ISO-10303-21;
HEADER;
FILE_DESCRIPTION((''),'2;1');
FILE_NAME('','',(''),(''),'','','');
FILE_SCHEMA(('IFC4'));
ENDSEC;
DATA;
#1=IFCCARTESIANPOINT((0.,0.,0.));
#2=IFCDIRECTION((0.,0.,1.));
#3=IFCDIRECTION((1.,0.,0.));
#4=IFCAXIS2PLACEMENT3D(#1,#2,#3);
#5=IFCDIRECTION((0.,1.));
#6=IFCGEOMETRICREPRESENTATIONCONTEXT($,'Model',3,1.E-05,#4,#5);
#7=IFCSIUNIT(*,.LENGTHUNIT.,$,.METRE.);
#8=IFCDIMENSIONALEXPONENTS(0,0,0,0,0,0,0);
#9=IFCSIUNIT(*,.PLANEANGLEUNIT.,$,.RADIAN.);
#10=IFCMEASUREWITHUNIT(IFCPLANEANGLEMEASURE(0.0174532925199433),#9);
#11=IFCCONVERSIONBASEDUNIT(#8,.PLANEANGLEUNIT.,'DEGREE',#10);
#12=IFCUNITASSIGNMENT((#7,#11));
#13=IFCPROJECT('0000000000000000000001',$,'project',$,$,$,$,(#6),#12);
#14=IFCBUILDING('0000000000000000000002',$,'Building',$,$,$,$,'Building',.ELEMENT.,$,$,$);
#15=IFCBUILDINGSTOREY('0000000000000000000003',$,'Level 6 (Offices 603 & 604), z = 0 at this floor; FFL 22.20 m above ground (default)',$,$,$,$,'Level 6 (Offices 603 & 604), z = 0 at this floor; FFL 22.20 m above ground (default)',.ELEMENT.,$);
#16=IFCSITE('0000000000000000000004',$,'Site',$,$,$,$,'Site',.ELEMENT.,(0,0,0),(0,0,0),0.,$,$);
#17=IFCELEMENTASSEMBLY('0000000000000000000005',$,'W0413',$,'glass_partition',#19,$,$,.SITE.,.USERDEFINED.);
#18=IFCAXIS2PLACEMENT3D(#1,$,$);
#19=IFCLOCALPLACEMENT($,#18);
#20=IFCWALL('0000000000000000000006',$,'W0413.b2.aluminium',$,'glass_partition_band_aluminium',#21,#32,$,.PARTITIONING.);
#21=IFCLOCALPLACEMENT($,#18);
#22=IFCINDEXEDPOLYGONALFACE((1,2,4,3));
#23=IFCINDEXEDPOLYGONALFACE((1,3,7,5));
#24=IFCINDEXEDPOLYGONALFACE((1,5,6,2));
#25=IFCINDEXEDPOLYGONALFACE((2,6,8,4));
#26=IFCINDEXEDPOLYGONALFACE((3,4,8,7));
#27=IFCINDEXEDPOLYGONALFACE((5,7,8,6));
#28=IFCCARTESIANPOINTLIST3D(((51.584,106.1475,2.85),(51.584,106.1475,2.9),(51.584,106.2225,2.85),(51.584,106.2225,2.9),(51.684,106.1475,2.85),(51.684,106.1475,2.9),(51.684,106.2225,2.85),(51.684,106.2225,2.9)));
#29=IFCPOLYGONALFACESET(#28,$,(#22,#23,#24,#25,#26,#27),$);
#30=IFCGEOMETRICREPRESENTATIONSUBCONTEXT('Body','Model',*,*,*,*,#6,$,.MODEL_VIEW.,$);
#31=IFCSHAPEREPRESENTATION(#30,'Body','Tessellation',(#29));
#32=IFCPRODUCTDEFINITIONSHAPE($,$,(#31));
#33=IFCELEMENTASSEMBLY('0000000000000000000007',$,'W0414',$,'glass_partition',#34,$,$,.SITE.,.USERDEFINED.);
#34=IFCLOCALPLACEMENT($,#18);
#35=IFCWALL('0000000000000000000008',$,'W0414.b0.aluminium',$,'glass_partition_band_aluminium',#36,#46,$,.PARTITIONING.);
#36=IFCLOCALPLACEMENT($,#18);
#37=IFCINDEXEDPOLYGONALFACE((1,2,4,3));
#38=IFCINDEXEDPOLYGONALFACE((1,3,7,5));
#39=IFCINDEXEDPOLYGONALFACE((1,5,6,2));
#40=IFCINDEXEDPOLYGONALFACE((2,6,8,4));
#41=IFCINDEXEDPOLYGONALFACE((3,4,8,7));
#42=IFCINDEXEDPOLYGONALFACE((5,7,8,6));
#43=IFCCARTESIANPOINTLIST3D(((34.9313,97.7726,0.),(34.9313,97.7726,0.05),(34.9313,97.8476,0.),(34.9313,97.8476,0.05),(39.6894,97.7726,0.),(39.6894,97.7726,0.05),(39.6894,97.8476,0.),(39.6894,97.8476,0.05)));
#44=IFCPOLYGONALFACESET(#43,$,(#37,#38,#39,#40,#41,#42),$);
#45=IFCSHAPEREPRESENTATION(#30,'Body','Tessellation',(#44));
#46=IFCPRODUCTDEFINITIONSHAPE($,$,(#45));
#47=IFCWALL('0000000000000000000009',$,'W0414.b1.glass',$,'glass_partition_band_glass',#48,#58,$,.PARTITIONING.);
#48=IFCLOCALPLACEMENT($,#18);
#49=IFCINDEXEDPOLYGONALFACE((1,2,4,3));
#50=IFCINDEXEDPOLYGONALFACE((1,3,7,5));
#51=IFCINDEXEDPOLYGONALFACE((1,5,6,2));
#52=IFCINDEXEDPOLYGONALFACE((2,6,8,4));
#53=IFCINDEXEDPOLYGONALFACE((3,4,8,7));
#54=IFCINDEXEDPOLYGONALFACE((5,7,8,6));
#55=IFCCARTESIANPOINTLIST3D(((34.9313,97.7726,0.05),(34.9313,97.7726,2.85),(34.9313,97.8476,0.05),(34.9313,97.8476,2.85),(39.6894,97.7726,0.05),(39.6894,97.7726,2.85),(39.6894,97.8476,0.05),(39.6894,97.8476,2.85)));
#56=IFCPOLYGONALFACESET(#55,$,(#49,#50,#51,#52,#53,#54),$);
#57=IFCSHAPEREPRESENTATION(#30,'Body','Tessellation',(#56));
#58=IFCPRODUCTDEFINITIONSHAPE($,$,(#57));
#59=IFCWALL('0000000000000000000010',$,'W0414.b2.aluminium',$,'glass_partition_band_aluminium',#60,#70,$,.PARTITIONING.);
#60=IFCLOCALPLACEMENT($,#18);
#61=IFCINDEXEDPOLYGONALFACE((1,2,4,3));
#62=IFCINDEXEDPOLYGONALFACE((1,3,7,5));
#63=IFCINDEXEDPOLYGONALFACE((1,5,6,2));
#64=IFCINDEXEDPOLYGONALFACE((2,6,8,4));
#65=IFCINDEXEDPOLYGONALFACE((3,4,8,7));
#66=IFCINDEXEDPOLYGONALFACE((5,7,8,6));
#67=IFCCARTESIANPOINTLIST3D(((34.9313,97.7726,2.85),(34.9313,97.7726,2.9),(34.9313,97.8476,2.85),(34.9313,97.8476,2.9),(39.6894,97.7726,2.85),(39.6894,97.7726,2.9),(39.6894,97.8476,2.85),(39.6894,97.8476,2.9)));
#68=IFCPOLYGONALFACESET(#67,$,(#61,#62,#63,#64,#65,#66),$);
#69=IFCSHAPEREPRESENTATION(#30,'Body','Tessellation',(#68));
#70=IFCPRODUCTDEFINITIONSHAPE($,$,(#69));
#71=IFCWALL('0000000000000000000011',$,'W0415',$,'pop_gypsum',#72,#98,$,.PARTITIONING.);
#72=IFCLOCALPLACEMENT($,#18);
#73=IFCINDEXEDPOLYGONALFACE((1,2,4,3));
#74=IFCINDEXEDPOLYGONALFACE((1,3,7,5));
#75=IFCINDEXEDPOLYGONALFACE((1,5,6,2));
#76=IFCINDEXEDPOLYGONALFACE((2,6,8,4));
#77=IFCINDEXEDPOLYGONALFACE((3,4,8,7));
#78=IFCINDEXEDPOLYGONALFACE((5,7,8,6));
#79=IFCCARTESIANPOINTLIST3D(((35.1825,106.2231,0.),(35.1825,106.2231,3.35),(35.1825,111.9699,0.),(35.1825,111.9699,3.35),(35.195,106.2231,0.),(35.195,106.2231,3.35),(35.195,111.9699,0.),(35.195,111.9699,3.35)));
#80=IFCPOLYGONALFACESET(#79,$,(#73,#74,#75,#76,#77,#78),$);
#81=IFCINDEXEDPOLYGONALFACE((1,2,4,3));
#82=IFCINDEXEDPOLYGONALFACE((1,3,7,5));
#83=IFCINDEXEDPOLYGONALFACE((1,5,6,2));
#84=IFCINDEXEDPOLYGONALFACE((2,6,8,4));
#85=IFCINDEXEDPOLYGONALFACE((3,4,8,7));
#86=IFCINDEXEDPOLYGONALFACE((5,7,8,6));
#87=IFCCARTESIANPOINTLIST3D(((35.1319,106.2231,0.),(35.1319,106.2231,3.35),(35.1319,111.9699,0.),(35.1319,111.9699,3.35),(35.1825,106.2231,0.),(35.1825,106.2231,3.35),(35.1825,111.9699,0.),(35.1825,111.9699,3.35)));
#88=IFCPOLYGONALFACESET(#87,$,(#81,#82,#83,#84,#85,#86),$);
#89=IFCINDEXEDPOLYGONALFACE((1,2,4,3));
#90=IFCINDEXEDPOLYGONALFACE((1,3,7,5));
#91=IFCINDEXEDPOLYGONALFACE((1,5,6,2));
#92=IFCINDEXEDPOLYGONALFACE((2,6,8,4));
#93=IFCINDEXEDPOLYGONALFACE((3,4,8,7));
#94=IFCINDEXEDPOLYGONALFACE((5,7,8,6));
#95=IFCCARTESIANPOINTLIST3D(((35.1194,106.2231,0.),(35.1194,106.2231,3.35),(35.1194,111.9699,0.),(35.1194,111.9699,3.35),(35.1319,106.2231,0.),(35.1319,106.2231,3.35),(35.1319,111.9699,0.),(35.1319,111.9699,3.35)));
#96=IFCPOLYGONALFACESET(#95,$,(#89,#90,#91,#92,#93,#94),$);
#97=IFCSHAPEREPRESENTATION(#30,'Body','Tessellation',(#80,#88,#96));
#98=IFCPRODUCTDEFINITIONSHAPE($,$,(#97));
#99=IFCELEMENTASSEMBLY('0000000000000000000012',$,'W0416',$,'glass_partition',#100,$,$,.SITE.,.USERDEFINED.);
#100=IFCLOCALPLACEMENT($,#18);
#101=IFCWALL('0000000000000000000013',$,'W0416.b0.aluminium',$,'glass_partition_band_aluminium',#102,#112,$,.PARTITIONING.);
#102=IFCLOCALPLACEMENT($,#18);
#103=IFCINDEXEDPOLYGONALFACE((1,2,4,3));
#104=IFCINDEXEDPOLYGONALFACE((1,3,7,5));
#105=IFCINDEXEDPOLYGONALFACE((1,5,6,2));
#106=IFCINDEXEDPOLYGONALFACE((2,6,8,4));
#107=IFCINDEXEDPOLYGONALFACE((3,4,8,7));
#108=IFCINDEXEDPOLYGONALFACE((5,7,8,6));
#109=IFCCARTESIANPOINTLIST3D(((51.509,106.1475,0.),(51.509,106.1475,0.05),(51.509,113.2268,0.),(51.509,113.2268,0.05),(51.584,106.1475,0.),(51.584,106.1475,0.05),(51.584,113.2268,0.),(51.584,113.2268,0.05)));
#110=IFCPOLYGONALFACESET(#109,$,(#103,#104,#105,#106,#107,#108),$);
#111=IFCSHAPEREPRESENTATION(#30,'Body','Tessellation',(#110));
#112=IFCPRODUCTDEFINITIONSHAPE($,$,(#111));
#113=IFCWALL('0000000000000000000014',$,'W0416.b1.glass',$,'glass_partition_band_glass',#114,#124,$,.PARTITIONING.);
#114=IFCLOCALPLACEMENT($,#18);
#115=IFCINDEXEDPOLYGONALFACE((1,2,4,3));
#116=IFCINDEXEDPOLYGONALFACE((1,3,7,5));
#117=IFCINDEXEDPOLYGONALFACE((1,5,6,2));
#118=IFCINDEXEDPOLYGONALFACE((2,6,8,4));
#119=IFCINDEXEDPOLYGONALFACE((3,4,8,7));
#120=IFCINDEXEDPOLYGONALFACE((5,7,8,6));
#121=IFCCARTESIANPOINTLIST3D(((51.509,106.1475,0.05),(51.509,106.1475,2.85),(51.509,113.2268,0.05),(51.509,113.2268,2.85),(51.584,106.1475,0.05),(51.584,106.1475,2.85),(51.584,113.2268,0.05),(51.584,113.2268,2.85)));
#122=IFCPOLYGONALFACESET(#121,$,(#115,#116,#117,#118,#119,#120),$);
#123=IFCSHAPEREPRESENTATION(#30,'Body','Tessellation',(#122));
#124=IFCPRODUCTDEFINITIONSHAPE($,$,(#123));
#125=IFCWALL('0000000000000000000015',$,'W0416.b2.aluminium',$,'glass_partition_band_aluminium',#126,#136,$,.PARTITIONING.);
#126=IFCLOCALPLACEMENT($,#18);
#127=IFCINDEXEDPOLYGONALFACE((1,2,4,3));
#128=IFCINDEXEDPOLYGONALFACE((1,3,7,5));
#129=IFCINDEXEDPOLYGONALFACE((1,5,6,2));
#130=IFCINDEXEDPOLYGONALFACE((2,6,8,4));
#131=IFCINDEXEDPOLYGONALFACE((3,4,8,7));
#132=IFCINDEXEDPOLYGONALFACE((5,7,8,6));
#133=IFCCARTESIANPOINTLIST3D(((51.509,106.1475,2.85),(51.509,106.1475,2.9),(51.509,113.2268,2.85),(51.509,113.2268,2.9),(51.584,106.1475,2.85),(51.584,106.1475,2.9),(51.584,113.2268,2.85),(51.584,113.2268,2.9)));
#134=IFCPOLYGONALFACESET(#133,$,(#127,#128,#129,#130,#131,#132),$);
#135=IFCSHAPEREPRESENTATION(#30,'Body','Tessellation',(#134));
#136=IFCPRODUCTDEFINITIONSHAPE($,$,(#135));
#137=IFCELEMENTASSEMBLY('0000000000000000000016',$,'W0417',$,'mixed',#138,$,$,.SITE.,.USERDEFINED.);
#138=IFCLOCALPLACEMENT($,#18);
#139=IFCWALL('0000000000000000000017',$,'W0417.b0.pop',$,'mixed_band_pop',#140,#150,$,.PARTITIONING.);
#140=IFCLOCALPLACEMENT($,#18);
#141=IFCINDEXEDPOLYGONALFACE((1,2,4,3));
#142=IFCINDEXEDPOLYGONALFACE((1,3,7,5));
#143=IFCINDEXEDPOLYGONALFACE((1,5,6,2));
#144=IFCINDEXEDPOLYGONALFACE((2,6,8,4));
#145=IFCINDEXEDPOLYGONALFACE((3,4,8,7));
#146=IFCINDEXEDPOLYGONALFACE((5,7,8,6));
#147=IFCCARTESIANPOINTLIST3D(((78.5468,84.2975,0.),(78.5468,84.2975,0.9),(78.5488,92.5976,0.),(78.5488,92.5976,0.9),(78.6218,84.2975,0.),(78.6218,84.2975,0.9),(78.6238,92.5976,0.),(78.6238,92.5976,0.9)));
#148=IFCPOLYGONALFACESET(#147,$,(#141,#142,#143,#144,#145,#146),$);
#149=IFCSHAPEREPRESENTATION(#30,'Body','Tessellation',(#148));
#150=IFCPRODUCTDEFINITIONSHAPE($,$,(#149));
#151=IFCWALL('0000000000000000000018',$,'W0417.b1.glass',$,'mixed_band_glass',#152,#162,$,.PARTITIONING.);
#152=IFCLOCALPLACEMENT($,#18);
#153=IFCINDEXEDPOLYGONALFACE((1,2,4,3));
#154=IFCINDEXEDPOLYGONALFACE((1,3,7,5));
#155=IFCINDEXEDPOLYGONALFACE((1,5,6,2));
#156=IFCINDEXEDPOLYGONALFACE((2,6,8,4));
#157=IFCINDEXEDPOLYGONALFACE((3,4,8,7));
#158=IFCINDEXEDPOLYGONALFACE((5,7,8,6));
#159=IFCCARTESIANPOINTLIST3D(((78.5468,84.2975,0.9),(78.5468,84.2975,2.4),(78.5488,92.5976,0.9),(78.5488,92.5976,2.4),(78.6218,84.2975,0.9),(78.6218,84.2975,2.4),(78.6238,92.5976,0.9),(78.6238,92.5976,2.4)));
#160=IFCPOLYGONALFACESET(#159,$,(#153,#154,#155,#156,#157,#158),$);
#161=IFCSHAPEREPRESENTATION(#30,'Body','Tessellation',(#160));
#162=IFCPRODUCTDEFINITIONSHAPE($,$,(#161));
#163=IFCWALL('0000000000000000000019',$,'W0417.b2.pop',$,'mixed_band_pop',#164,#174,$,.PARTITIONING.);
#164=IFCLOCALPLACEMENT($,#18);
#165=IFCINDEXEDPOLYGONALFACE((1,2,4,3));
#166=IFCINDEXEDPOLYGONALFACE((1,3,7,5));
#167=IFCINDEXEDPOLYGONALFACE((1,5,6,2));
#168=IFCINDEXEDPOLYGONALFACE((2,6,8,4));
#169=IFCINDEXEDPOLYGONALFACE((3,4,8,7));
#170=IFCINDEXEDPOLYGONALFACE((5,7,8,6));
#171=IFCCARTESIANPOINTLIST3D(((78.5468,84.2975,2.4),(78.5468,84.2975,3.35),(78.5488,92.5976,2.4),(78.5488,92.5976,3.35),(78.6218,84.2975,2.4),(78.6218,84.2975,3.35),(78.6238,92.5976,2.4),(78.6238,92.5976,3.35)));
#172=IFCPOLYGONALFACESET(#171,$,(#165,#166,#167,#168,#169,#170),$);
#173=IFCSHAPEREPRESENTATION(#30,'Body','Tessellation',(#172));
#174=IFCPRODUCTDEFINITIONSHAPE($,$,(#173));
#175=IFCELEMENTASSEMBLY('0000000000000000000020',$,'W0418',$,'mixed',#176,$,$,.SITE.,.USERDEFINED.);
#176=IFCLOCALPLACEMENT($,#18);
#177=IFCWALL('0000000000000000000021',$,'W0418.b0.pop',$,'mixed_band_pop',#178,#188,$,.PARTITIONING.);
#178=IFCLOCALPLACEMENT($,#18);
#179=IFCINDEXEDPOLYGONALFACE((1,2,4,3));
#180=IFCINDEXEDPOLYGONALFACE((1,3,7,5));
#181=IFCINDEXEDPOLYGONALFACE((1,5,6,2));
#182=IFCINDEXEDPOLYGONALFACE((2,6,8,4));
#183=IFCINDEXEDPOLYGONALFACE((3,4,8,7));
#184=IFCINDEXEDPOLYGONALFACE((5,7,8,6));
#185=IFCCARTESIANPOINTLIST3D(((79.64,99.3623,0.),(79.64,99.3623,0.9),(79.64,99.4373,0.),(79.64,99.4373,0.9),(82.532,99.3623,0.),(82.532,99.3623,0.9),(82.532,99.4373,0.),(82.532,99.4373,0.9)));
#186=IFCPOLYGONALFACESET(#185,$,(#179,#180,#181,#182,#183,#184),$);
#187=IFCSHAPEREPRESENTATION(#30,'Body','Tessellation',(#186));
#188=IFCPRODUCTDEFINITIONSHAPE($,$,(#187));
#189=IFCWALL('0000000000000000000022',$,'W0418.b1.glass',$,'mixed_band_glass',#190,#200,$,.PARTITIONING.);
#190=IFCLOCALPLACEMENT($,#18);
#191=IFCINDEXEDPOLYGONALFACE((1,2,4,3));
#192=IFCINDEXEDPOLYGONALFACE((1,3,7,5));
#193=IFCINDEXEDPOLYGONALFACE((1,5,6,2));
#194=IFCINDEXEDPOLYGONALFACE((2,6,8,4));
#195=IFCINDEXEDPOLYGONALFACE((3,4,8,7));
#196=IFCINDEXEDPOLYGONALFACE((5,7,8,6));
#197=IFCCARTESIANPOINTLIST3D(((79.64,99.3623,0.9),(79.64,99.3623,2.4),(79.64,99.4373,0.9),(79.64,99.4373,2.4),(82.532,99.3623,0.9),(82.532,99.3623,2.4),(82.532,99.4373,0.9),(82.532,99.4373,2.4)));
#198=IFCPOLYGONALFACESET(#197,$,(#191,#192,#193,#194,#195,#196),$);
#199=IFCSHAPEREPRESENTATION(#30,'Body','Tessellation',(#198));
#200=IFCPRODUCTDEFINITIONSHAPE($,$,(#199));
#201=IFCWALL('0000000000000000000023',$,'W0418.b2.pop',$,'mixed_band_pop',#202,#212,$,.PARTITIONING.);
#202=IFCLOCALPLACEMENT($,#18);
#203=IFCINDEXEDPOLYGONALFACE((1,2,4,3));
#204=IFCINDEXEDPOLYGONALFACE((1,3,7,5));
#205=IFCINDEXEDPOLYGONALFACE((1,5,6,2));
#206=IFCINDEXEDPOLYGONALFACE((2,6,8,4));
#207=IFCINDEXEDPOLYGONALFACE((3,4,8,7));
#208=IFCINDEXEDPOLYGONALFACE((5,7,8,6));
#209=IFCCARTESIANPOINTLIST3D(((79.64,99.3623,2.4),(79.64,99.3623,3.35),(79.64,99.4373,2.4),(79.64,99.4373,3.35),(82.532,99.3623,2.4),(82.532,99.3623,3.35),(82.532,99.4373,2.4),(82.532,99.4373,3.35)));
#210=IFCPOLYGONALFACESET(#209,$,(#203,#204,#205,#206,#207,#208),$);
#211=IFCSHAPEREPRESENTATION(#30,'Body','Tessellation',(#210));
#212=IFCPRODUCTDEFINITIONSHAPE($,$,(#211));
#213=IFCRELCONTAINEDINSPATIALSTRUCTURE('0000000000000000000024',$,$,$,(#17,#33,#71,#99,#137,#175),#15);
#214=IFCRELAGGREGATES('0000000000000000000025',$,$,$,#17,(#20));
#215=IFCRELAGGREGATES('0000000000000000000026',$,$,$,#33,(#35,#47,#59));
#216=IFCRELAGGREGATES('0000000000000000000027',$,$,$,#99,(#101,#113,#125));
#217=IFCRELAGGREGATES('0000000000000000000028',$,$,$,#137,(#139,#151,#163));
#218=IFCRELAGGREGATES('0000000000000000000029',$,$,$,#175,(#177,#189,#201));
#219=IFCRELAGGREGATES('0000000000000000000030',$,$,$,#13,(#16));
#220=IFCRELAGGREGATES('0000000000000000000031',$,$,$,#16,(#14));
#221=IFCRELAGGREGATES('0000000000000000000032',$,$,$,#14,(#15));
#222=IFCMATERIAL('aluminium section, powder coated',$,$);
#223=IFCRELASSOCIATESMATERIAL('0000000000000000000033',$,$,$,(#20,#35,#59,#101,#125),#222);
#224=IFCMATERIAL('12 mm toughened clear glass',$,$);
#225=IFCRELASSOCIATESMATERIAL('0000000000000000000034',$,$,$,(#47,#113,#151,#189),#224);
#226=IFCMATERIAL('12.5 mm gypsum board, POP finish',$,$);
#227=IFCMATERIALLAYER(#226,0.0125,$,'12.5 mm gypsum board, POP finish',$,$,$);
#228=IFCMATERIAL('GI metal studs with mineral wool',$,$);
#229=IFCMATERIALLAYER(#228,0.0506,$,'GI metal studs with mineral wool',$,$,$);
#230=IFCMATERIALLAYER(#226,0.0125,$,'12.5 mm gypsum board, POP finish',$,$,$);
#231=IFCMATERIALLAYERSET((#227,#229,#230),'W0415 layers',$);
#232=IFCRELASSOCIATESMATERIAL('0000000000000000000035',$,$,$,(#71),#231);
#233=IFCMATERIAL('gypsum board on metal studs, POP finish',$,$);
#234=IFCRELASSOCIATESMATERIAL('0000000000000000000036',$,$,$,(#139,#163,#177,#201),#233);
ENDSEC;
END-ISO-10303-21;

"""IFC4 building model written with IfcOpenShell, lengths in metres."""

from ifc_helpers import new_model, entity, si_unit, converted_unit, direction, frame, frame_2d, origin_with_axes, place, context, subcontext, project, spatial, rectangle, extrude, material, layer, layer_set, layer_usage, element, aggregate, save


model = new_model("IFC4")

# Units and contexts
model_context = context("Model", 3, precision=1e-05, world=origin_with_axes(), true_north=direction((0.0, 1.0)))
body_context = subcontext(model_context, "Body", "Model", "MODEL_VIEW")
ifc_project = project(units=[si_unit("LENGTHUNIT", "METRE"), converted_unit("PLANEANGLEUNIT", "DEGREE", entity("IfcPlaneAngleMeasure", 0.0174532925199433), si_unit("PLANEANGLEUNIT", "RADIAN"), dimensions=[0, 0, 0, 0, 0, 0, 0])], contexts=[model_context])

# Site, building, storey
site = spatial("IfcSite", under=ifc_project, Name="Site", LongName="Site", CompositionType="ELEMENT", RefLatitude=(0, 0, 0), RefLongitude=(0, 0, 0), RefElevation=0.0)
building = spatial("IfcBuilding", under=site, Name="Building", LongName="Building", CompositionType="ELEMENT")
storey = spatial("IfcBuildingStorey", under=building, Name="Level 6 (Offices 603 & 604), z = 0 at this floor; FFL 22.20 m above ground (default)", LongName="Level 6 (Offices 603 & 604), z = 0 at this floor; FFL 22.20 m above ground (default)", CompositionType="ELEMENT")

# Element assembly, wall
assembly_1 = element("IfcElementAssembly", 1, inside=storey, Name="W0413", ObjectType="glass_partition", AssemblyPlace="SITE", PredefinedType="USERDEFINED")
ifc_material_1 = material(Name="aluminium section, powder coated")
placement = place(None, origin_with_axes())
wall_1 = element("IfcWall", 2, at=placement, material=ifc_material_1, Name="W0413.b2.aluminium", ObjectType="glass_partition_band_aluminium", PredefinedType="PARTITIONING", context=body_context, shape_type="SweptSolid", body=[
    extrude(rectangle(XDim=0.1, YDim=0.075, at=frame_2d((0.0, 0.0), x_axis=(1.0, 0.0))), frame((51.634, 106.185, 2.85), z_axis=(0.0, 0.0, 1.0), x_axis=(1.0, 0.0, 0.0)), (0.0, 0.0, 1.0), 0.05),
])
aggregate(assembly_1, [wall_1])

# Element assembly, walls
assembly_2 = element("IfcElementAssembly", 3, inside=storey, Name="W0414", ObjectType="glass_partition", AssemblyPlace="SITE", PredefinedType="USERDEFINED")
wall_2 = element("IfcWall", 4, at=placement, material=ifc_material_1, Name="W0414.b0.aluminium", ObjectType="glass_partition_band_aluminium", PredefinedType="PARTITIONING", context=body_context, shape_type="SweptSolid", body=[
    extrude(rectangle(XDim=4.7581, YDim=0.075, at=frame_2d((0.0, 0.0), x_axis=(1.0, 0.0))), frame((37.3103, 97.8101, 0.0), z_axis=(0.0, 0.0, 1.0), x_axis=(1.0, 0.0, 0.0)), (0.0, 0.0, 1.0), 0.05),
])
ifc_material_2 = material(Name="12 mm toughened clear glass")
wall_3 = element("IfcWall", 5, at=placement, material=ifc_material_2, Name="W0414.b1.glass", ObjectType="glass_partition_band_glass", PredefinedType="PARTITIONING", context=body_context, shape_type="SweptSolid", body=[
    extrude(rectangle(XDim=4.7581, YDim=0.075, at=frame_2d((0.0, 0.0), x_axis=(1.0, 0.0))), frame((37.3103, 97.8101, 0.05), z_axis=(0.0, 0.0, 1.0), x_axis=(1.0, 0.0, 0.0)), (0.0, 0.0, 1.0), 2.8),
])
wall_4 = element("IfcWall", 6, at=placement, material=ifc_material_1, Name="W0414.b2.aluminium", ObjectType="glass_partition_band_aluminium", PredefinedType="PARTITIONING", context=body_context, shape_type="SweptSolid", body=[
    extrude(rectangle(XDim=4.7581, YDim=0.075, at=frame_2d((0.0, 0.0), x_axis=(1.0, 0.0))), frame((37.3103, 97.8101, 2.85), z_axis=(0.0, 0.0, 1.0), x_axis=(1.0, 0.0, 0.0)), (0.0, 0.0, 1.0), 0.05),
])
aggregate(assembly_2, [wall_2, wall_3, wall_4])

# Wall
ifc_material_3 = material(Name="12.5 mm gypsum board, POP finish")
ifc_layer_1 = layer(ifc_material_3, 0.0125, Name="12.5 mm gypsum board, POP finish")
ifc_material_4 = material(Name="GI metal studs with mineral wool")
ifc_layer_2 = layer(ifc_material_4, 0.0506, Name="GI metal studs with mineral wool")
ifc_layer_3 = layer(ifc_material_3, 0.0125, Name="12.5 mm gypsum board, POP finish")
ifc_layer_set = layer_set([ifc_layer_1, ifc_layer_2, ifc_layer_3], Name="W0415 layers")
ifc_layer_usage = layer_usage(ifc_layer_set, "AXIS2", "POSITIVE", -0.0378)
element("IfcWall", 7, at=placement, inside=storey, material=ifc_layer_usage, Name="W0415", ObjectType="pop_gypsum", PredefinedType="PARTITIONING", context=body_context, shape_type="SweptSolid", body=[
    extrude(rectangle(XDim=5.7468, YDim=0.0125, at=frame_2d((0.0, 0.0), x_axis=(0.0, 1.0))), frame((35.1887, 109.0965, 0.0), z_axis=(0.0, 0.0, 1.0), x_axis=(1.0, 0.0, 0.0)), (0.0, 0.0, 1.0), 3.35),
    extrude(rectangle(XDim=5.7468, YDim=0.0506, at=frame_2d((-0.0315, 0.0), x_axis=(0.0, 1.0))), frame((35.1887, 109.0965, 0.0), z_axis=(0.0, 0.0, 1.0), x_axis=(1.0, 0.0, 0.0)), (0.0, 0.0, 1.0), 3.35),
    extrude(rectangle(XDim=5.7468, YDim=0.0125, at=frame_2d((-0.0631, 0.0), x_axis=(0.0, 1.0))), frame((35.1887, 109.0965, 0.0), z_axis=(0.0, 0.0, 1.0), x_axis=(1.0, 0.0, 0.0)), (0.0, 0.0, 1.0), 3.35),
])

# Element assemblies, walls
assembly_3 = element("IfcElementAssembly", 8, inside=storey, Name="W0416", ObjectType="glass_partition", AssemblyPlace="SITE", PredefinedType="USERDEFINED")
wall_5 = element("IfcWall", 9, at=placement, material=ifc_material_1, Name="W0416.b0.aluminium", ObjectType="glass_partition_band_aluminium", PredefinedType="PARTITIONING", context=body_context, shape_type="SweptSolid", body=[
    extrude(rectangle(XDim=7.0793, YDim=0.075, at=frame_2d((0.0, 0.0), x_axis=(0.0, 1.0))), frame((51.5465, 109.6872, 0.0), z_axis=(0.0, 0.0, 1.0), x_axis=(1.0, 0.0, 0.0)), (0.0, 0.0, 1.0), 0.05),
])
wall_6 = element("IfcWall", 10, at=placement, material=ifc_material_2, Name="W0416.b1.glass", ObjectType="glass_partition_band_glass", PredefinedType="PARTITIONING", context=body_context, shape_type="SweptSolid", body=[
    extrude(rectangle(XDim=7.0793, YDim=0.075, at=frame_2d((0.0, 0.0), x_axis=(0.0, 1.0))), frame((51.5465, 109.6872, 0.05), z_axis=(0.0, 0.0, 1.0), x_axis=(1.0, 0.0, 0.0)), (0.0, 0.0, 1.0), 2.8),
])
wall_7 = element("IfcWall", 11, at=placement, material=ifc_material_1, Name="W0416.b2.aluminium", ObjectType="glass_partition_band_aluminium", PredefinedType="PARTITIONING", context=body_context, shape_type="SweptSolid", body=[
    extrude(rectangle(XDim=7.0793, YDim=0.075, at=frame_2d((0.0, 0.0), x_axis=(0.0, 1.0))), frame((51.5465, 109.6872, 2.85), z_axis=(0.0, 0.0, 1.0), x_axis=(1.0, 0.0, 0.0)), (0.0, 0.0, 1.0), 0.05),
])
aggregate(assembly_3, [wall_5, wall_6, wall_7])
assembly_4 = element("IfcElementAssembly", 12, inside=storey, Name="W0417", ObjectType="mixed", AssemblyPlace="SITE", PredefinedType="USERDEFINED")
ifc_material_5 = material(Name="gypsum board on metal studs, POP finish")
wall_8 = element("IfcWall", 13, at=placement, material=ifc_material_5, Name="W0417.b0.pop", ObjectType="mixed_band_pop", PredefinedType="PARTITIONING", context=body_context, shape_type="SweptSolid", body=[
    extrude(rectangle(XDim=8.3001, YDim=0.075, at=frame_2d((0.0, 0.0), x_axis=(0.000241, 1.0))), frame((78.5853, 88.4476, 0.0), z_axis=(0.0, 0.0, 1.0), x_axis=(1.0, 0.0, 0.0)), (0.0, 0.0, 1.0), 0.9),
])
wall_9 = element("IfcWall", 14, at=placement, material=ifc_material_2, Name="W0417.b1.glass", ObjectType="mixed_band_glass", PredefinedType="PARTITIONING", context=body_context, shape_type="SweptSolid", body=[
    extrude(rectangle(XDim=8.3001, YDim=0.075, at=frame_2d((0.0, 0.0), x_axis=(0.000241, 1.0))), frame((78.5853, 88.4476, 0.9), z_axis=(0.0, 0.0, 1.0), x_axis=(1.0, 0.0, 0.0)), (0.0, 0.0, 1.0), 1.5),
])
wall_10 = element("IfcWall", 15, at=placement, material=ifc_material_5, Name="W0417.b2.pop", ObjectType="mixed_band_pop", PredefinedType="PARTITIONING", context=body_context, shape_type="SweptSolid", body=[
    extrude(rectangle(XDim=8.3001, YDim=0.075, at=frame_2d((0.0, 0.0), x_axis=(0.000241, 1.0))), frame((78.5853, 88.4476, 2.4), z_axis=(0.0, 0.0, 1.0), x_axis=(1.0, 0.0, 0.0)), (0.0, 0.0, 1.0), 0.95),
])
aggregate(assembly_4, [wall_8, wall_9, wall_10])
assembly_5 = element("IfcElementAssembly", 16, inside=storey, Name="W0418", ObjectType="mixed", AssemblyPlace="SITE", PredefinedType="USERDEFINED")
wall_11 = element("IfcWall", 17, at=placement, material=ifc_material_5, Name="W0418.b0.pop", ObjectType="mixed_band_pop", PredefinedType="PARTITIONING", context=body_context, shape_type="SweptSolid", body=[
    extrude(rectangle(XDim=2.892, YDim=0.075, at=frame_2d((0.0, 0.0), x_axis=(1.0, 0.0))), frame((81.086, 99.3998, 0.0), z_axis=(0.0, 0.0, 1.0), x_axis=(1.0, 0.0, 0.0)), (0.0, 0.0, 1.0), 0.9),
])
wall_12 = element("IfcWall", 18, at=placement, material=ifc_material_2, Name="W0418.b1.glass", ObjectType="mixed_band_glass", PredefinedType="PARTITIONING", context=body_context, shape_type="SweptSolid", body=[
    extrude(rectangle(XDim=2.892, YDim=0.075, at=frame_2d((0.0, 0.0), x_axis=(1.0, 0.0))), frame((81.086, 99.3998, 0.9), z_axis=(0.0, 0.0, 1.0), x_axis=(1.0, 0.0, 0.0)), (0.0, 0.0, 1.0), 1.5),
])
wall_13 = element("IfcWall", 19, at=placement, material=ifc_material_5, Name="W0418.b2.pop", ObjectType="mixed_band_pop", PredefinedType="PARTITIONING", context=body_context, shape_type="SweptSolid", body=[
    extrude(rectangle(XDim=2.892, YDim=0.075, at=frame_2d((0.0, 0.0), x_axis=(1.0, 0.0))), frame((81.086, 99.3998, 2.4), z_axis=(0.0, 0.0, 1.0), x_axis=(1.0, 0.0, 0.0)), (0.0, 0.0, 1.0), 0.95),
])
aggregate(assembly_5, [wall_11, wall_12, wall_13])

save(model, "model.ifc")
